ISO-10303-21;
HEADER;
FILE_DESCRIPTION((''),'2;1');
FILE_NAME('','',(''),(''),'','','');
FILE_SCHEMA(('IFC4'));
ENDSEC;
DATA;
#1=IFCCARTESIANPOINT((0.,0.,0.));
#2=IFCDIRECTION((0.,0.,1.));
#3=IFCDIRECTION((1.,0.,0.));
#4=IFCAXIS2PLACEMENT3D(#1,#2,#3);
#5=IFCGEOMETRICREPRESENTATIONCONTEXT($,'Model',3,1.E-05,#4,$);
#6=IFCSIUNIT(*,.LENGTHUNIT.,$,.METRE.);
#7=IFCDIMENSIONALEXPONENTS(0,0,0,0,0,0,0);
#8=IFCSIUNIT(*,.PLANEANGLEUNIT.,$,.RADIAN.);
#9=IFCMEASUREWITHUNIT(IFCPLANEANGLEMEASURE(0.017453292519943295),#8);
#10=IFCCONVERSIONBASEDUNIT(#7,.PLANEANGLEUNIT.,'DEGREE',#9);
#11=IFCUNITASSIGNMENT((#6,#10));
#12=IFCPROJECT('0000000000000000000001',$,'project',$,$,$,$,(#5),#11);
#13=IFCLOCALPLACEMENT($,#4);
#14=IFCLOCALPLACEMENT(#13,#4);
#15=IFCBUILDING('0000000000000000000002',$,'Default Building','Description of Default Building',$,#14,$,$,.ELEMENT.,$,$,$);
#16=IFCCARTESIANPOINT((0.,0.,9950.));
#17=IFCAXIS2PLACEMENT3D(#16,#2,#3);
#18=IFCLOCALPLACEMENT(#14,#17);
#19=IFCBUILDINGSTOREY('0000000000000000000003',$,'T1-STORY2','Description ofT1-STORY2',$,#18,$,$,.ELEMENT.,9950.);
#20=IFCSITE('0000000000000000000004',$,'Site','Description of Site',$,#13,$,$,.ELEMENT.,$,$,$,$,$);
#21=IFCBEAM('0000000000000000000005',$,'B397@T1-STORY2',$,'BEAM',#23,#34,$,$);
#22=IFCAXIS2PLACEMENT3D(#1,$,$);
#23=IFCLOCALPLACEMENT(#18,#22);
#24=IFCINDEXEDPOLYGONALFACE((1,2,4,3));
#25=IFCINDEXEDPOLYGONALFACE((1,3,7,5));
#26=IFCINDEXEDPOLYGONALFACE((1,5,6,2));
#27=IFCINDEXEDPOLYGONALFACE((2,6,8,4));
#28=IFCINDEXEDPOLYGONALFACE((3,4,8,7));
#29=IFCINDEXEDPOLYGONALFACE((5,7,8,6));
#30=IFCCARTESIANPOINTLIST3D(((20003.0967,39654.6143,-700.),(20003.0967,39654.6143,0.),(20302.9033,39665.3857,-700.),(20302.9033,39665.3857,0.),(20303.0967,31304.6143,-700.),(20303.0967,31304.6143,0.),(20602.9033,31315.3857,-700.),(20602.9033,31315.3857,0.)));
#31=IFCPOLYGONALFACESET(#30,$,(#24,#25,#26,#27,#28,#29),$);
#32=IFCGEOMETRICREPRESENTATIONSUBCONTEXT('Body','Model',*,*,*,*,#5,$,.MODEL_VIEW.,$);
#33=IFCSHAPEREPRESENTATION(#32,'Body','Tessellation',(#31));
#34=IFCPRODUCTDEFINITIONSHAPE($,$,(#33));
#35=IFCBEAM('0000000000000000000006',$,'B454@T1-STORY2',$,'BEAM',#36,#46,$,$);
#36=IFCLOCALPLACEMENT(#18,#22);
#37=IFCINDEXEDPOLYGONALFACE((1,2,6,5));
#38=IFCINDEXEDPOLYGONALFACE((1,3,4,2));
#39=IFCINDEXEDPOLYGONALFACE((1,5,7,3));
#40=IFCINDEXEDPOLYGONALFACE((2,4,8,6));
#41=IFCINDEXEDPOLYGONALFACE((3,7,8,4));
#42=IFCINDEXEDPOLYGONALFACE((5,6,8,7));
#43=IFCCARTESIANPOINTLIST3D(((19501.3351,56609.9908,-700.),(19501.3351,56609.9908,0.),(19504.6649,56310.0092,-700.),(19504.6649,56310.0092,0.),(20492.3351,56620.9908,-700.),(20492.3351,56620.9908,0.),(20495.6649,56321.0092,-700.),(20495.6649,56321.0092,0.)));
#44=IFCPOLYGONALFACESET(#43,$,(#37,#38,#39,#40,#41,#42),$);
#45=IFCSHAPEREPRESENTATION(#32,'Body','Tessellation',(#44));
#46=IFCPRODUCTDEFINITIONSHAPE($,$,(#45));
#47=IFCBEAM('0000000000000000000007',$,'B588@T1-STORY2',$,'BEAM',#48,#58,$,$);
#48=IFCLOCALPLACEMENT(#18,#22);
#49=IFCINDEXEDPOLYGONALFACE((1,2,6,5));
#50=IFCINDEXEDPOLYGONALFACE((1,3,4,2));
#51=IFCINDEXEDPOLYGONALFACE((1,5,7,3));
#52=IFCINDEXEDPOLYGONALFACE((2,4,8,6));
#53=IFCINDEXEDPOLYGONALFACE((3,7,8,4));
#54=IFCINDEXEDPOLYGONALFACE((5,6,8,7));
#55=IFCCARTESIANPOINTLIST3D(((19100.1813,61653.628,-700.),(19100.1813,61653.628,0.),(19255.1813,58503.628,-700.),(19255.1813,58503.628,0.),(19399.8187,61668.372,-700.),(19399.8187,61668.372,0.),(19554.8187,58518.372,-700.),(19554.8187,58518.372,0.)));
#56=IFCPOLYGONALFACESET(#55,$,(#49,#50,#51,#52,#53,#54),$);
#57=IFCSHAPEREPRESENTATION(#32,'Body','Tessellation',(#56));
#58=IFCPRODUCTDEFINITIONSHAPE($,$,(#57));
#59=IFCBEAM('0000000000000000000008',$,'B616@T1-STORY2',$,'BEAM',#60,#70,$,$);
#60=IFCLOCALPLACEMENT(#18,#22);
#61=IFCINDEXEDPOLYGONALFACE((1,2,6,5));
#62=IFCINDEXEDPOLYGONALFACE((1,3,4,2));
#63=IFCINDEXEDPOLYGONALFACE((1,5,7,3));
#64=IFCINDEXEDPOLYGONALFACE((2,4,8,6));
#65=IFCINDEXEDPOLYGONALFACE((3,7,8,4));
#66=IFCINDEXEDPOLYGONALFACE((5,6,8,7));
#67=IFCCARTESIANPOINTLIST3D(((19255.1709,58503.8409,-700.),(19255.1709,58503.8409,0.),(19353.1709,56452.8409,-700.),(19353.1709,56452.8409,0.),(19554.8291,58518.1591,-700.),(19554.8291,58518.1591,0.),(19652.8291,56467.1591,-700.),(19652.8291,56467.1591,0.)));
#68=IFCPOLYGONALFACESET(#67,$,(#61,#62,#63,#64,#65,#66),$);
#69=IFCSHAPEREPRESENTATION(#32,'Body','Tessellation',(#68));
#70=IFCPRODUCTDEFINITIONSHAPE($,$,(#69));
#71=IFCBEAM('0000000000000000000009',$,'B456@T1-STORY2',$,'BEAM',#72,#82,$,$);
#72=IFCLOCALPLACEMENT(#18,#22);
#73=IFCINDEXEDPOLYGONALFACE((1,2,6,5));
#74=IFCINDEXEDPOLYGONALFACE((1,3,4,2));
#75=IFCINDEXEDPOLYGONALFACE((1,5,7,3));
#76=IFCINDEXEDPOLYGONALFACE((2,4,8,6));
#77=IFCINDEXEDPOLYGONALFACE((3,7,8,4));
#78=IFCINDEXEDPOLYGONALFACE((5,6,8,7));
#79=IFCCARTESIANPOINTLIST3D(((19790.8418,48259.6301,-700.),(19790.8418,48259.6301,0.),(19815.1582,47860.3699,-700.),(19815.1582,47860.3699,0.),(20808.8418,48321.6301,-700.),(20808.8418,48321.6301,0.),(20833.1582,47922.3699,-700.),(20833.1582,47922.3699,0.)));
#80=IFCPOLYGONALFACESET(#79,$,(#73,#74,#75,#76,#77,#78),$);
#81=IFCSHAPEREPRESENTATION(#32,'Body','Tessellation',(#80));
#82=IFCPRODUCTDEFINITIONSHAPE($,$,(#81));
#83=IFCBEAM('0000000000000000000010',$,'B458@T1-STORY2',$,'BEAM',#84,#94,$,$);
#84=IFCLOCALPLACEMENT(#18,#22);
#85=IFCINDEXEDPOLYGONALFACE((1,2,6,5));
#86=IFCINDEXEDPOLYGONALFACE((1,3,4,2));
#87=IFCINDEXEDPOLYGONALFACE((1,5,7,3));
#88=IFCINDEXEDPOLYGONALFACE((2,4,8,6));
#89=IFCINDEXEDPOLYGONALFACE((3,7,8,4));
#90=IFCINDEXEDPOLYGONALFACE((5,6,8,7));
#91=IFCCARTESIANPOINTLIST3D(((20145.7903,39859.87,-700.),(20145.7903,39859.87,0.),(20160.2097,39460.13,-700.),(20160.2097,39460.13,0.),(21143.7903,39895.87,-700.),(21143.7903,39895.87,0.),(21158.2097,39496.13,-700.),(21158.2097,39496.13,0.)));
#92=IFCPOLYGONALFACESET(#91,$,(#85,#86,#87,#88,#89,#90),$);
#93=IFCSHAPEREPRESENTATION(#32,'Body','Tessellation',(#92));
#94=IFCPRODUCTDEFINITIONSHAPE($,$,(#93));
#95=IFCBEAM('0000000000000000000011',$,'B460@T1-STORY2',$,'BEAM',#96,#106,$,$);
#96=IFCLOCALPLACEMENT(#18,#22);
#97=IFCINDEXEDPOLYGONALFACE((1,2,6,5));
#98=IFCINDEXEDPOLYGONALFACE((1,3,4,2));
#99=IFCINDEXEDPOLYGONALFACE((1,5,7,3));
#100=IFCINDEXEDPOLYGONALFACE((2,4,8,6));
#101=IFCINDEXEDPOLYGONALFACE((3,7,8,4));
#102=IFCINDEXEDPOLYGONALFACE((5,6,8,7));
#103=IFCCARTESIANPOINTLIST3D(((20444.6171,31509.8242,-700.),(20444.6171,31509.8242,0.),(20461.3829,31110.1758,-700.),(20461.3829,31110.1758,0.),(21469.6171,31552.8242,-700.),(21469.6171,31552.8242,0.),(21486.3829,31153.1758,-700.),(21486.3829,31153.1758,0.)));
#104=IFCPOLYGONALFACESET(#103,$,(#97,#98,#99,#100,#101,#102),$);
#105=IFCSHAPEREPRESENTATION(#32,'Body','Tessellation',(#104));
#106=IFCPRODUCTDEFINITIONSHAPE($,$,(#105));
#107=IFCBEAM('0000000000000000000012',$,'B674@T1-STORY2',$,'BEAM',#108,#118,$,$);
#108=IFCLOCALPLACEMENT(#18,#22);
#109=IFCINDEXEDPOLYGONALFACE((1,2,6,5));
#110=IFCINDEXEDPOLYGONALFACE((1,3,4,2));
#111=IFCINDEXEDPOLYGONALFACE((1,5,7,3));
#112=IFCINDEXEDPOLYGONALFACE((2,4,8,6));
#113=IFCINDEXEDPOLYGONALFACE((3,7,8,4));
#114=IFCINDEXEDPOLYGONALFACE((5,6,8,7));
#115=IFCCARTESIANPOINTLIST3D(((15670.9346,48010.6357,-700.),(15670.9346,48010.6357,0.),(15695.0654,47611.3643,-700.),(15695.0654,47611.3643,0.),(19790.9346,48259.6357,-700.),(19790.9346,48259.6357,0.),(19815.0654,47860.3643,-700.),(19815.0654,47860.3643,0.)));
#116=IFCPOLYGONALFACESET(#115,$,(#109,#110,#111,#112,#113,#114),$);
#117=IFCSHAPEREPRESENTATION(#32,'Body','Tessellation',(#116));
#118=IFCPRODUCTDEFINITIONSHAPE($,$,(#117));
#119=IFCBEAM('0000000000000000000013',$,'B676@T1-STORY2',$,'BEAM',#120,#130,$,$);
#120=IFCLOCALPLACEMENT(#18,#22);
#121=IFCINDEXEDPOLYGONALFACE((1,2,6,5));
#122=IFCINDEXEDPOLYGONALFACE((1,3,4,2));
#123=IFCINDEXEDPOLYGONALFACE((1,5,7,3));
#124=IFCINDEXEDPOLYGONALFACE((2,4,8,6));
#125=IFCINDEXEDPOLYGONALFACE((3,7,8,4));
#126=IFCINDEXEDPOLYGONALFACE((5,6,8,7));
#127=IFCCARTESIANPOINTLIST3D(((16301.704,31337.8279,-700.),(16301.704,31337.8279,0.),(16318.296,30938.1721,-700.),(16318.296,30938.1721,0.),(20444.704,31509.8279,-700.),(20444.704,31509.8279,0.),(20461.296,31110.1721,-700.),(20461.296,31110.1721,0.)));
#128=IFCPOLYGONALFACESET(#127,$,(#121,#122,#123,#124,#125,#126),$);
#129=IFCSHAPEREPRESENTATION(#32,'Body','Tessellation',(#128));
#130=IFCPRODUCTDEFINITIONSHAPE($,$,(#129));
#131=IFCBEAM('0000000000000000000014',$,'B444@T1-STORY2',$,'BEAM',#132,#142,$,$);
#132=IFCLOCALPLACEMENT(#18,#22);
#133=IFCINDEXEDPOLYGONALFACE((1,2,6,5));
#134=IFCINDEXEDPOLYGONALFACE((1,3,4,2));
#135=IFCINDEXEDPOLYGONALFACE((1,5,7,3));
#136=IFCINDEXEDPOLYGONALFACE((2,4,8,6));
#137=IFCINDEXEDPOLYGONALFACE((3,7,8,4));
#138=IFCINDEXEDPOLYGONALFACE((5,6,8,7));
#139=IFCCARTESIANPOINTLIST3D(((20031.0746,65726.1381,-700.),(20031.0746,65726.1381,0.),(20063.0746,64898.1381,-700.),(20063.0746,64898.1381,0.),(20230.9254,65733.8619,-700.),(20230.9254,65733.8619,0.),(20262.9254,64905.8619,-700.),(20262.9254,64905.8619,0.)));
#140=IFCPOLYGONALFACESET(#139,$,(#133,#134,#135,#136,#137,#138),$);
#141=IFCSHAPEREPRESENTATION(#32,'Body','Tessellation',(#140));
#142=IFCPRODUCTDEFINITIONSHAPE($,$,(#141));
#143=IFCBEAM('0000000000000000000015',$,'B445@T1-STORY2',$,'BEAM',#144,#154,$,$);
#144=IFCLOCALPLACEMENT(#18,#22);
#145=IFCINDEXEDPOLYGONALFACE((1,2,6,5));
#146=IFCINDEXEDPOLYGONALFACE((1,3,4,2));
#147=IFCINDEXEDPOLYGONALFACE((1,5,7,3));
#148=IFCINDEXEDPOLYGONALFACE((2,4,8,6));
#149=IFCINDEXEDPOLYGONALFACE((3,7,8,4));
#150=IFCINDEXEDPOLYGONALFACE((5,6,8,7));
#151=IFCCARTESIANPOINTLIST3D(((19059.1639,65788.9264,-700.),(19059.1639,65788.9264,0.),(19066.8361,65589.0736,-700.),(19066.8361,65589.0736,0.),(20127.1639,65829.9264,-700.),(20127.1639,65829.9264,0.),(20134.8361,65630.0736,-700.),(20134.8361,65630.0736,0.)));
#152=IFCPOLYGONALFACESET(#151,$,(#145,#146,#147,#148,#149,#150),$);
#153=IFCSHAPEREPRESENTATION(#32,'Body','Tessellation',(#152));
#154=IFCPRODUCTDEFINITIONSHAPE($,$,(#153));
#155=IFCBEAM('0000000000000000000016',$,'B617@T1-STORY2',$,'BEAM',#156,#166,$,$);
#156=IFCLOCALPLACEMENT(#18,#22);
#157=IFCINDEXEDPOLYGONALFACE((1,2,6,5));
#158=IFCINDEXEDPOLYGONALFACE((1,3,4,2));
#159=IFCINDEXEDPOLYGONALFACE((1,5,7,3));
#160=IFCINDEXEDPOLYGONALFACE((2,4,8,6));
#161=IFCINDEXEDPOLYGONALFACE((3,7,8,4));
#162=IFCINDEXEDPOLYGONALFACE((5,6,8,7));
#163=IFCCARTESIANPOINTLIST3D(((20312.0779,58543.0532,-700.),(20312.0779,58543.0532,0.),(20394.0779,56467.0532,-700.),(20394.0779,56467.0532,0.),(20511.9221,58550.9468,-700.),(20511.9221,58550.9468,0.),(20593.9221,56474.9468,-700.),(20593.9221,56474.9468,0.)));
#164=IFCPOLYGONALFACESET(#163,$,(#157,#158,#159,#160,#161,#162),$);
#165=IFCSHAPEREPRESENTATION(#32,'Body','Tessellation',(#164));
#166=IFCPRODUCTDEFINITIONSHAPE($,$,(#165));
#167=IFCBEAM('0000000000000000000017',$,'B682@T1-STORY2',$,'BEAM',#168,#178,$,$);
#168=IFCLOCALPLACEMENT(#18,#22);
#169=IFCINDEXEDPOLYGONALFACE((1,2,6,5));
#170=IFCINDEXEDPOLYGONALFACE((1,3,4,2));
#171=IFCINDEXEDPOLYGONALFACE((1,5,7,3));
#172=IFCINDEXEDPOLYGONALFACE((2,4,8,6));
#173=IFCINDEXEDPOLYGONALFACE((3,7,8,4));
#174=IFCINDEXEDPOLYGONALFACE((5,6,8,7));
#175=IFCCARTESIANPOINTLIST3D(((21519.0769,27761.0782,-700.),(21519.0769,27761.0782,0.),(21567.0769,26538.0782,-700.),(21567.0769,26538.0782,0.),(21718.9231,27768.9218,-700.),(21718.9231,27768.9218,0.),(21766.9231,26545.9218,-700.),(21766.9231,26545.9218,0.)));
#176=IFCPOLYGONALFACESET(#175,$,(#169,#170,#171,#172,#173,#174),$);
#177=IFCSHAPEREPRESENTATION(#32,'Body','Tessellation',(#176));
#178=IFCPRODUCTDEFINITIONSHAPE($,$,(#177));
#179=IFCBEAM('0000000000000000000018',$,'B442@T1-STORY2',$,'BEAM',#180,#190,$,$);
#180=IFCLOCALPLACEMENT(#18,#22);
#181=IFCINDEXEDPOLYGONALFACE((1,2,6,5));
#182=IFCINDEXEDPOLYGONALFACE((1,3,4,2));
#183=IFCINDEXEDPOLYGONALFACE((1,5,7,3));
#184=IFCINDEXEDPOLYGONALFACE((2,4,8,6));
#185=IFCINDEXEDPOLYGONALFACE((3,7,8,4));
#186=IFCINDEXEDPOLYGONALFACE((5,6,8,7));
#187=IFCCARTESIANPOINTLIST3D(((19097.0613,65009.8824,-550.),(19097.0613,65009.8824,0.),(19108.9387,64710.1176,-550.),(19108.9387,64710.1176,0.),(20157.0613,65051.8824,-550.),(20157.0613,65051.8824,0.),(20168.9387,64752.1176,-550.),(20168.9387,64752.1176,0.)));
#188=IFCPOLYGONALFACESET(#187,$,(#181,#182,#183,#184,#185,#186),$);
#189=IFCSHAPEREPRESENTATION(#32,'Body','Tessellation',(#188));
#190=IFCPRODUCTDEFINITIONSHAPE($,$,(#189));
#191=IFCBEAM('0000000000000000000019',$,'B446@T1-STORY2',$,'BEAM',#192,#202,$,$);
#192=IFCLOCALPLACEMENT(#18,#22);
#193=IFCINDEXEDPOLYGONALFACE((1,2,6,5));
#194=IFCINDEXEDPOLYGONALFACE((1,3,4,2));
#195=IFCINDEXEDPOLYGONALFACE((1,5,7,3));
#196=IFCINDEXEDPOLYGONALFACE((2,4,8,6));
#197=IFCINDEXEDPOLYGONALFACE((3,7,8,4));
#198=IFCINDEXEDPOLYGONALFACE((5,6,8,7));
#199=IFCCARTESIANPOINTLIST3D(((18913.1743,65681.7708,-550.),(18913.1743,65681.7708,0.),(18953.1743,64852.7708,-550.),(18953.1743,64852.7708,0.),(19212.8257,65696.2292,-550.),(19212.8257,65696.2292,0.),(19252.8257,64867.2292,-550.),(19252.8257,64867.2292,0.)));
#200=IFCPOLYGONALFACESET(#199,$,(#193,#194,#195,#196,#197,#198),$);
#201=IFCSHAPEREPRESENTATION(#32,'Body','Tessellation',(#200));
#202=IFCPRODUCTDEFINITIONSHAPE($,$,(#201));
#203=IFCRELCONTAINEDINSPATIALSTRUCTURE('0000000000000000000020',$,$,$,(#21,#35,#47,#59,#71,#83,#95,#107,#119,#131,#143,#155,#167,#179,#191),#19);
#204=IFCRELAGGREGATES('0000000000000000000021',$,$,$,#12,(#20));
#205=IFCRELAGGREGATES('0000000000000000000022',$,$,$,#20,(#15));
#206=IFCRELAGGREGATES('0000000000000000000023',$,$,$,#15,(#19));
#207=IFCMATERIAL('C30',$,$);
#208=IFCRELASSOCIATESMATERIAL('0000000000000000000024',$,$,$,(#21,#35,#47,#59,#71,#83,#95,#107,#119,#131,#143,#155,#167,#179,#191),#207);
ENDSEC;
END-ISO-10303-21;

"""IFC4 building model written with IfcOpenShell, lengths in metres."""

from ifc_helpers import new_model, entity, si_unit, converted_unit, frame, origin_with_axes, place, context, subcontext, project, spatial, rectangle, extrude, material, element, save


model = new_model("IFC4")

# Units and contexts
model_context = context("Model", 3, precision=1e-05, world=origin_with_axes())
body_context = subcontext(model_context, "Body", "Model", "MODEL_VIEW")
ifc_project = project(units=[si_unit("LENGTHUNIT", "METRE"), converted_unit("PLANEANGLEUNIT", "DEGREE", entity("IfcPlaneAngleMeasure", 0.017453292519943295), si_unit("PLANEANGLEUNIT", "RADIAN"), dimensions=[0, 0, 0, 0, 0, 0, 0])], contexts=[model_context])

# Site, building, storey
site_placement = place(None, origin_with_axes())
site = spatial("IfcSite", under=ifc_project, at=site_placement, Name="Site", Description="Description of Site", CompositionType="ELEMENT")
building_placement = place(site_placement, origin_with_axes())
building = spatial("IfcBuilding", under=site, at=building_placement, Name="Default Building", Description="Description of Default Building", CompositionType="ELEMENT")
storey_placement = place(building_placement, frame((0.0, 0.0, 9950.0), z_axis=(0.0, 0.0, 1.0), x_axis=(1.0, 0.0, 0.0)))
storey = spatial("IfcBuildingStorey", under=building, at=storey_placement, Name="T1-STORY2", Description="Description ofT1-STORY2", CompositionType="ELEMENT", Elevation=9950.0)

# Beams
ifc_material_1 = material(Name="C30")
beam_1_placement = place(storey_placement, frame((20153.0, 39660.0, -350.0), z_axis=(0.035905, -0.999355, 0.0), x_axis=(0.999355, 0.035905, 0.0)))
element("IfcBeam", 1, at=beam_1_placement, inside=storey, material=ifc_material_1, Name="B397@T1-STORY2", ObjectType="BEAM", context=body_context, shape_type="SweptSolid", body=[
    extrude(rectangle(XDim=300.0, YDim=700.0), origin_with_axes(), (0.0, 0.0, 1.0), 8355.3875),
])
beam_2_placement = place(storey_placement, frame((19503.0, 56460.0, -350.0), z_axis=(0.999938, 0.011099, 0.0), x_axis=(-0.011099, 0.999938, 0.0)))
element("IfcBeam", 2, at=beam_2_placement, inside=storey, material=ifc_material_1, Name="B454@T1-STORY2", ObjectType="BEAM", context=body_context, shape_type="SweptSolid", body=[
    extrude(rectangle(XDim=300.0, YDim=700.0), origin_with_axes(), (0.0, 0.0, 1.0), 991.061),
])
beam_3_placement = place(storey_placement, frame((19250.0, 61661.0, -350.0), z_axis=(0.049147, -0.998792, 0.0), x_axis=(0.998792, 0.049147, 0.0)))
element("IfcBeam", 3, at=beam_3_placement, inside=storey, material=ifc_material_1, Name="B588@T1-STORY2", ObjectType="BEAM", context=body_context, shape_type="SweptSolid", body=[
    extrude(rectangle(XDim=300.0, YDim=700.0), origin_with_axes(), (0.0, 0.0, 1.0), 3153.8112),
])
beam_4_placement = place(storey_placement, frame((19405.0, 58511.0, -350.0), z_axis=(0.047727, -0.99886, 0.0), x_axis=(0.99886, 0.047727, 0.0)))
element("IfcBeam", 4, at=beam_4_placement, inside=storey, material=ifc_material_1, Name="B616@T1-STORY2", ObjectType="BEAM", context=body_context, shape_type="SweptSolid", body=[
    extrude(rectangle(XDim=300.0, YDim=700.0), origin_with_axes(), (0.0, 0.0, 1.0), 2053.34),
])
beam_5_placement = place(storey_placement, frame((19803.0, 48060.0, -350.0), z_axis=(0.998151, 0.060791, 0.0), x_axis=(-0.060791, 0.998151, 0.0)))
element("IfcBeam", 5, at=beam_5_placement, inside=storey, material=ifc_material_1, Name="B456@T1-STORY2", ObjectType="BEAM", context=body_context, shape_type="SweptSolid", body=[
    extrude(rectangle(XDim=400.0, YDim=700.0), origin_with_axes(), (0.0, 0.0, 1.0), 1019.8863),
])
beam_6_placement = place(storey_placement, frame((20153.0, 39660.0, -350.0), z_axis=(0.99935, 0.036049, 0.0), x_axis=(-0.036049, 0.99935, 0.0)))
element("IfcBeam", 6, at=beam_6_placement, inside=storey, material=ifc_material_1, Name="B458@T1-STORY2", ObjectType="BEAM", context=body_context, shape_type="SweptSolid", body=[
    extrude(rectangle(XDim=400.0, YDim=700.0), origin_with_axes(), (0.0, 0.0, 1.0), 998.6491),
])
beam_7_placement = place(storey_placement, frame((20453.0, 31310.0, -350.0), z_axis=(0.999121, 0.041914, 0.0), x_axis=(-0.041914, 0.999121, 0.0)))
element("IfcBeam", 7, at=beam_7_placement, inside=storey, material=ifc_material_1, Name="B460@T1-STORY2", ObjectType="BEAM", context=body_context, shape_type="SweptSolid", body=[
    extrude(rectangle(XDim=400.0, YDim=700.0), origin_with_axes(), (0.0, 0.0, 1.0), 1025.9016),
])
beam_8_placement = place(storey_placement, frame((15683.0, 47811.0, -350.0), z_axis=(0.998179, 0.060327, 0.0), x_axis=(-0.060327, 0.998179, 0.0)))
element("IfcBeam", 8, at=beam_8_placement, inside=storey, material=ifc_material_1, Name="B674@T1-STORY2", ObjectType="BEAM", context=body_context, shape_type="SweptSolid", body=[
    extrude(rectangle(XDim=400.0, YDim=700.0), origin_with_axes(), (0.0, 0.0, 1.0), 4127.5175),
])
beam_9_placement = place(storey_placement, frame((16310.0, 31138.0, -350.0), z_axis=(0.999139, 0.04148, 0.0), x_axis=(-0.04148, 0.999139, 0.0)))
element("IfcBeam", 9, at=beam_9_placement, inside=storey, material=ifc_material_1, Name="B676@T1-STORY2", ObjectType="BEAM", context=body_context, shape_type="SweptSolid", body=[
    extrude(rectangle(XDim=400.0, YDim=700.0), origin_with_axes(), (0.0, 0.0, 1.0), 4146.5688),
])
beam_10_placement = place(storey_placement, frame((20131.0, 65730.0, -350.0), z_axis=(0.038619, -0.999254, 0.0), x_axis=(0.999254, 0.038619, 0.0)))
element("IfcBeam", 10, at=beam_10_placement, inside=storey, material=ifc_material_1, Name="B444@T1-STORY2", ObjectType="BEAM", context=body_context, shape_type="SweptSolid", body=[
    extrude(rectangle(XDim=200.0, YDim=700.0), origin_with_axes(), (0.0, 0.0, 1.0), 828.6181),
])
beam_11_placement = place(storey_placement, frame((19063.0, 65689.0, -350.0), z_axis=(0.999264, 0.038361, 0.0), x_axis=(-0.038361, 0.999264, 0.0)))
element("IfcBeam", 11, at=beam_11_placement, inside=storey, material=ifc_material_1, Name="B445@T1-STORY2", ObjectType="BEAM", context=body_context, shape_type="SweptSolid", body=[
    extrude(rectangle(XDim=200.0, YDim=700.0), origin_with_axes(), (0.0, 0.0, 1.0), 1068.7867),
])
beam_12_placement = place(storey_placement, frame((20412.0, 58547.0, -350.0), z_axis=(0.039468, -0.999221, 0.0), x_axis=(0.999221, 0.039468, 0.0)))
element("IfcBeam", 12, at=beam_12_placement, inside=storey, material=ifc_material_1, Name="B617@T1-STORY2", ObjectType="BEAM", context=body_context, shape_type="SweptSolid", body=[
    extrude(rectangle(XDim=200.0, YDim=700.0), origin_with_axes(), (0.0, 0.0, 1.0), 2077.6188),
])
beam_13_placement = place(storey_placement, frame((21619.0, 27765.0, -350.0), z_axis=(0.039218, -0.999231, 0.0), x_axis=(0.999231, 0.039218, 0.0)))
element("IfcBeam", 13, at=beam_13_placement, inside=storey, material=ifc_material_1, Name="B682@T1-STORY2", ObjectType="BEAM", context=body_context, shape_type="SweptSolid", body=[
    extrude(rectangle(XDim=200.0, YDim=700.0), origin_with_axes(), (0.0, 0.0, 1.0), 1223.9416),
])
beam_14_placement = place(storey_placement, frame((19103.0, 64860.0, -275.0), z_axis=(0.999216, 0.039592, 0.0), x_axis=(-0.039592, 0.999216, 0.0)))
element("IfcBeam", 14, at=beam_14_placement, inside=storey, material=ifc_material_1, Name="B442@T1-STORY2", ObjectType="BEAM", context=body_context, shape_type="SweptSolid", body=[
    extrude(rectangle(XDim=300.0, YDim=550.0), origin_with_axes(), (0.0, 0.0, 1.0), 1060.8317),
])
beam_15_placement = place(storey_placement, frame((19063.0, 65689.0, -275.0), z_axis=(0.048195, -0.998838, 0.0), x_axis=(0.998838, 0.048195, 0.0)))
element("IfcBeam", 15, at=beam_15_placement, inside=storey, material=ifc_material_1, Name="B446@T1-STORY2", ObjectType="BEAM", context=body_context, shape_type="SweptSolid", body=[
    extrude(rectangle(XDim=300.0, YDim=550.0), origin_with_axes(), (0.0, 0.0, 1.0), 829.9645),
])

save(model, "model.ifc")
